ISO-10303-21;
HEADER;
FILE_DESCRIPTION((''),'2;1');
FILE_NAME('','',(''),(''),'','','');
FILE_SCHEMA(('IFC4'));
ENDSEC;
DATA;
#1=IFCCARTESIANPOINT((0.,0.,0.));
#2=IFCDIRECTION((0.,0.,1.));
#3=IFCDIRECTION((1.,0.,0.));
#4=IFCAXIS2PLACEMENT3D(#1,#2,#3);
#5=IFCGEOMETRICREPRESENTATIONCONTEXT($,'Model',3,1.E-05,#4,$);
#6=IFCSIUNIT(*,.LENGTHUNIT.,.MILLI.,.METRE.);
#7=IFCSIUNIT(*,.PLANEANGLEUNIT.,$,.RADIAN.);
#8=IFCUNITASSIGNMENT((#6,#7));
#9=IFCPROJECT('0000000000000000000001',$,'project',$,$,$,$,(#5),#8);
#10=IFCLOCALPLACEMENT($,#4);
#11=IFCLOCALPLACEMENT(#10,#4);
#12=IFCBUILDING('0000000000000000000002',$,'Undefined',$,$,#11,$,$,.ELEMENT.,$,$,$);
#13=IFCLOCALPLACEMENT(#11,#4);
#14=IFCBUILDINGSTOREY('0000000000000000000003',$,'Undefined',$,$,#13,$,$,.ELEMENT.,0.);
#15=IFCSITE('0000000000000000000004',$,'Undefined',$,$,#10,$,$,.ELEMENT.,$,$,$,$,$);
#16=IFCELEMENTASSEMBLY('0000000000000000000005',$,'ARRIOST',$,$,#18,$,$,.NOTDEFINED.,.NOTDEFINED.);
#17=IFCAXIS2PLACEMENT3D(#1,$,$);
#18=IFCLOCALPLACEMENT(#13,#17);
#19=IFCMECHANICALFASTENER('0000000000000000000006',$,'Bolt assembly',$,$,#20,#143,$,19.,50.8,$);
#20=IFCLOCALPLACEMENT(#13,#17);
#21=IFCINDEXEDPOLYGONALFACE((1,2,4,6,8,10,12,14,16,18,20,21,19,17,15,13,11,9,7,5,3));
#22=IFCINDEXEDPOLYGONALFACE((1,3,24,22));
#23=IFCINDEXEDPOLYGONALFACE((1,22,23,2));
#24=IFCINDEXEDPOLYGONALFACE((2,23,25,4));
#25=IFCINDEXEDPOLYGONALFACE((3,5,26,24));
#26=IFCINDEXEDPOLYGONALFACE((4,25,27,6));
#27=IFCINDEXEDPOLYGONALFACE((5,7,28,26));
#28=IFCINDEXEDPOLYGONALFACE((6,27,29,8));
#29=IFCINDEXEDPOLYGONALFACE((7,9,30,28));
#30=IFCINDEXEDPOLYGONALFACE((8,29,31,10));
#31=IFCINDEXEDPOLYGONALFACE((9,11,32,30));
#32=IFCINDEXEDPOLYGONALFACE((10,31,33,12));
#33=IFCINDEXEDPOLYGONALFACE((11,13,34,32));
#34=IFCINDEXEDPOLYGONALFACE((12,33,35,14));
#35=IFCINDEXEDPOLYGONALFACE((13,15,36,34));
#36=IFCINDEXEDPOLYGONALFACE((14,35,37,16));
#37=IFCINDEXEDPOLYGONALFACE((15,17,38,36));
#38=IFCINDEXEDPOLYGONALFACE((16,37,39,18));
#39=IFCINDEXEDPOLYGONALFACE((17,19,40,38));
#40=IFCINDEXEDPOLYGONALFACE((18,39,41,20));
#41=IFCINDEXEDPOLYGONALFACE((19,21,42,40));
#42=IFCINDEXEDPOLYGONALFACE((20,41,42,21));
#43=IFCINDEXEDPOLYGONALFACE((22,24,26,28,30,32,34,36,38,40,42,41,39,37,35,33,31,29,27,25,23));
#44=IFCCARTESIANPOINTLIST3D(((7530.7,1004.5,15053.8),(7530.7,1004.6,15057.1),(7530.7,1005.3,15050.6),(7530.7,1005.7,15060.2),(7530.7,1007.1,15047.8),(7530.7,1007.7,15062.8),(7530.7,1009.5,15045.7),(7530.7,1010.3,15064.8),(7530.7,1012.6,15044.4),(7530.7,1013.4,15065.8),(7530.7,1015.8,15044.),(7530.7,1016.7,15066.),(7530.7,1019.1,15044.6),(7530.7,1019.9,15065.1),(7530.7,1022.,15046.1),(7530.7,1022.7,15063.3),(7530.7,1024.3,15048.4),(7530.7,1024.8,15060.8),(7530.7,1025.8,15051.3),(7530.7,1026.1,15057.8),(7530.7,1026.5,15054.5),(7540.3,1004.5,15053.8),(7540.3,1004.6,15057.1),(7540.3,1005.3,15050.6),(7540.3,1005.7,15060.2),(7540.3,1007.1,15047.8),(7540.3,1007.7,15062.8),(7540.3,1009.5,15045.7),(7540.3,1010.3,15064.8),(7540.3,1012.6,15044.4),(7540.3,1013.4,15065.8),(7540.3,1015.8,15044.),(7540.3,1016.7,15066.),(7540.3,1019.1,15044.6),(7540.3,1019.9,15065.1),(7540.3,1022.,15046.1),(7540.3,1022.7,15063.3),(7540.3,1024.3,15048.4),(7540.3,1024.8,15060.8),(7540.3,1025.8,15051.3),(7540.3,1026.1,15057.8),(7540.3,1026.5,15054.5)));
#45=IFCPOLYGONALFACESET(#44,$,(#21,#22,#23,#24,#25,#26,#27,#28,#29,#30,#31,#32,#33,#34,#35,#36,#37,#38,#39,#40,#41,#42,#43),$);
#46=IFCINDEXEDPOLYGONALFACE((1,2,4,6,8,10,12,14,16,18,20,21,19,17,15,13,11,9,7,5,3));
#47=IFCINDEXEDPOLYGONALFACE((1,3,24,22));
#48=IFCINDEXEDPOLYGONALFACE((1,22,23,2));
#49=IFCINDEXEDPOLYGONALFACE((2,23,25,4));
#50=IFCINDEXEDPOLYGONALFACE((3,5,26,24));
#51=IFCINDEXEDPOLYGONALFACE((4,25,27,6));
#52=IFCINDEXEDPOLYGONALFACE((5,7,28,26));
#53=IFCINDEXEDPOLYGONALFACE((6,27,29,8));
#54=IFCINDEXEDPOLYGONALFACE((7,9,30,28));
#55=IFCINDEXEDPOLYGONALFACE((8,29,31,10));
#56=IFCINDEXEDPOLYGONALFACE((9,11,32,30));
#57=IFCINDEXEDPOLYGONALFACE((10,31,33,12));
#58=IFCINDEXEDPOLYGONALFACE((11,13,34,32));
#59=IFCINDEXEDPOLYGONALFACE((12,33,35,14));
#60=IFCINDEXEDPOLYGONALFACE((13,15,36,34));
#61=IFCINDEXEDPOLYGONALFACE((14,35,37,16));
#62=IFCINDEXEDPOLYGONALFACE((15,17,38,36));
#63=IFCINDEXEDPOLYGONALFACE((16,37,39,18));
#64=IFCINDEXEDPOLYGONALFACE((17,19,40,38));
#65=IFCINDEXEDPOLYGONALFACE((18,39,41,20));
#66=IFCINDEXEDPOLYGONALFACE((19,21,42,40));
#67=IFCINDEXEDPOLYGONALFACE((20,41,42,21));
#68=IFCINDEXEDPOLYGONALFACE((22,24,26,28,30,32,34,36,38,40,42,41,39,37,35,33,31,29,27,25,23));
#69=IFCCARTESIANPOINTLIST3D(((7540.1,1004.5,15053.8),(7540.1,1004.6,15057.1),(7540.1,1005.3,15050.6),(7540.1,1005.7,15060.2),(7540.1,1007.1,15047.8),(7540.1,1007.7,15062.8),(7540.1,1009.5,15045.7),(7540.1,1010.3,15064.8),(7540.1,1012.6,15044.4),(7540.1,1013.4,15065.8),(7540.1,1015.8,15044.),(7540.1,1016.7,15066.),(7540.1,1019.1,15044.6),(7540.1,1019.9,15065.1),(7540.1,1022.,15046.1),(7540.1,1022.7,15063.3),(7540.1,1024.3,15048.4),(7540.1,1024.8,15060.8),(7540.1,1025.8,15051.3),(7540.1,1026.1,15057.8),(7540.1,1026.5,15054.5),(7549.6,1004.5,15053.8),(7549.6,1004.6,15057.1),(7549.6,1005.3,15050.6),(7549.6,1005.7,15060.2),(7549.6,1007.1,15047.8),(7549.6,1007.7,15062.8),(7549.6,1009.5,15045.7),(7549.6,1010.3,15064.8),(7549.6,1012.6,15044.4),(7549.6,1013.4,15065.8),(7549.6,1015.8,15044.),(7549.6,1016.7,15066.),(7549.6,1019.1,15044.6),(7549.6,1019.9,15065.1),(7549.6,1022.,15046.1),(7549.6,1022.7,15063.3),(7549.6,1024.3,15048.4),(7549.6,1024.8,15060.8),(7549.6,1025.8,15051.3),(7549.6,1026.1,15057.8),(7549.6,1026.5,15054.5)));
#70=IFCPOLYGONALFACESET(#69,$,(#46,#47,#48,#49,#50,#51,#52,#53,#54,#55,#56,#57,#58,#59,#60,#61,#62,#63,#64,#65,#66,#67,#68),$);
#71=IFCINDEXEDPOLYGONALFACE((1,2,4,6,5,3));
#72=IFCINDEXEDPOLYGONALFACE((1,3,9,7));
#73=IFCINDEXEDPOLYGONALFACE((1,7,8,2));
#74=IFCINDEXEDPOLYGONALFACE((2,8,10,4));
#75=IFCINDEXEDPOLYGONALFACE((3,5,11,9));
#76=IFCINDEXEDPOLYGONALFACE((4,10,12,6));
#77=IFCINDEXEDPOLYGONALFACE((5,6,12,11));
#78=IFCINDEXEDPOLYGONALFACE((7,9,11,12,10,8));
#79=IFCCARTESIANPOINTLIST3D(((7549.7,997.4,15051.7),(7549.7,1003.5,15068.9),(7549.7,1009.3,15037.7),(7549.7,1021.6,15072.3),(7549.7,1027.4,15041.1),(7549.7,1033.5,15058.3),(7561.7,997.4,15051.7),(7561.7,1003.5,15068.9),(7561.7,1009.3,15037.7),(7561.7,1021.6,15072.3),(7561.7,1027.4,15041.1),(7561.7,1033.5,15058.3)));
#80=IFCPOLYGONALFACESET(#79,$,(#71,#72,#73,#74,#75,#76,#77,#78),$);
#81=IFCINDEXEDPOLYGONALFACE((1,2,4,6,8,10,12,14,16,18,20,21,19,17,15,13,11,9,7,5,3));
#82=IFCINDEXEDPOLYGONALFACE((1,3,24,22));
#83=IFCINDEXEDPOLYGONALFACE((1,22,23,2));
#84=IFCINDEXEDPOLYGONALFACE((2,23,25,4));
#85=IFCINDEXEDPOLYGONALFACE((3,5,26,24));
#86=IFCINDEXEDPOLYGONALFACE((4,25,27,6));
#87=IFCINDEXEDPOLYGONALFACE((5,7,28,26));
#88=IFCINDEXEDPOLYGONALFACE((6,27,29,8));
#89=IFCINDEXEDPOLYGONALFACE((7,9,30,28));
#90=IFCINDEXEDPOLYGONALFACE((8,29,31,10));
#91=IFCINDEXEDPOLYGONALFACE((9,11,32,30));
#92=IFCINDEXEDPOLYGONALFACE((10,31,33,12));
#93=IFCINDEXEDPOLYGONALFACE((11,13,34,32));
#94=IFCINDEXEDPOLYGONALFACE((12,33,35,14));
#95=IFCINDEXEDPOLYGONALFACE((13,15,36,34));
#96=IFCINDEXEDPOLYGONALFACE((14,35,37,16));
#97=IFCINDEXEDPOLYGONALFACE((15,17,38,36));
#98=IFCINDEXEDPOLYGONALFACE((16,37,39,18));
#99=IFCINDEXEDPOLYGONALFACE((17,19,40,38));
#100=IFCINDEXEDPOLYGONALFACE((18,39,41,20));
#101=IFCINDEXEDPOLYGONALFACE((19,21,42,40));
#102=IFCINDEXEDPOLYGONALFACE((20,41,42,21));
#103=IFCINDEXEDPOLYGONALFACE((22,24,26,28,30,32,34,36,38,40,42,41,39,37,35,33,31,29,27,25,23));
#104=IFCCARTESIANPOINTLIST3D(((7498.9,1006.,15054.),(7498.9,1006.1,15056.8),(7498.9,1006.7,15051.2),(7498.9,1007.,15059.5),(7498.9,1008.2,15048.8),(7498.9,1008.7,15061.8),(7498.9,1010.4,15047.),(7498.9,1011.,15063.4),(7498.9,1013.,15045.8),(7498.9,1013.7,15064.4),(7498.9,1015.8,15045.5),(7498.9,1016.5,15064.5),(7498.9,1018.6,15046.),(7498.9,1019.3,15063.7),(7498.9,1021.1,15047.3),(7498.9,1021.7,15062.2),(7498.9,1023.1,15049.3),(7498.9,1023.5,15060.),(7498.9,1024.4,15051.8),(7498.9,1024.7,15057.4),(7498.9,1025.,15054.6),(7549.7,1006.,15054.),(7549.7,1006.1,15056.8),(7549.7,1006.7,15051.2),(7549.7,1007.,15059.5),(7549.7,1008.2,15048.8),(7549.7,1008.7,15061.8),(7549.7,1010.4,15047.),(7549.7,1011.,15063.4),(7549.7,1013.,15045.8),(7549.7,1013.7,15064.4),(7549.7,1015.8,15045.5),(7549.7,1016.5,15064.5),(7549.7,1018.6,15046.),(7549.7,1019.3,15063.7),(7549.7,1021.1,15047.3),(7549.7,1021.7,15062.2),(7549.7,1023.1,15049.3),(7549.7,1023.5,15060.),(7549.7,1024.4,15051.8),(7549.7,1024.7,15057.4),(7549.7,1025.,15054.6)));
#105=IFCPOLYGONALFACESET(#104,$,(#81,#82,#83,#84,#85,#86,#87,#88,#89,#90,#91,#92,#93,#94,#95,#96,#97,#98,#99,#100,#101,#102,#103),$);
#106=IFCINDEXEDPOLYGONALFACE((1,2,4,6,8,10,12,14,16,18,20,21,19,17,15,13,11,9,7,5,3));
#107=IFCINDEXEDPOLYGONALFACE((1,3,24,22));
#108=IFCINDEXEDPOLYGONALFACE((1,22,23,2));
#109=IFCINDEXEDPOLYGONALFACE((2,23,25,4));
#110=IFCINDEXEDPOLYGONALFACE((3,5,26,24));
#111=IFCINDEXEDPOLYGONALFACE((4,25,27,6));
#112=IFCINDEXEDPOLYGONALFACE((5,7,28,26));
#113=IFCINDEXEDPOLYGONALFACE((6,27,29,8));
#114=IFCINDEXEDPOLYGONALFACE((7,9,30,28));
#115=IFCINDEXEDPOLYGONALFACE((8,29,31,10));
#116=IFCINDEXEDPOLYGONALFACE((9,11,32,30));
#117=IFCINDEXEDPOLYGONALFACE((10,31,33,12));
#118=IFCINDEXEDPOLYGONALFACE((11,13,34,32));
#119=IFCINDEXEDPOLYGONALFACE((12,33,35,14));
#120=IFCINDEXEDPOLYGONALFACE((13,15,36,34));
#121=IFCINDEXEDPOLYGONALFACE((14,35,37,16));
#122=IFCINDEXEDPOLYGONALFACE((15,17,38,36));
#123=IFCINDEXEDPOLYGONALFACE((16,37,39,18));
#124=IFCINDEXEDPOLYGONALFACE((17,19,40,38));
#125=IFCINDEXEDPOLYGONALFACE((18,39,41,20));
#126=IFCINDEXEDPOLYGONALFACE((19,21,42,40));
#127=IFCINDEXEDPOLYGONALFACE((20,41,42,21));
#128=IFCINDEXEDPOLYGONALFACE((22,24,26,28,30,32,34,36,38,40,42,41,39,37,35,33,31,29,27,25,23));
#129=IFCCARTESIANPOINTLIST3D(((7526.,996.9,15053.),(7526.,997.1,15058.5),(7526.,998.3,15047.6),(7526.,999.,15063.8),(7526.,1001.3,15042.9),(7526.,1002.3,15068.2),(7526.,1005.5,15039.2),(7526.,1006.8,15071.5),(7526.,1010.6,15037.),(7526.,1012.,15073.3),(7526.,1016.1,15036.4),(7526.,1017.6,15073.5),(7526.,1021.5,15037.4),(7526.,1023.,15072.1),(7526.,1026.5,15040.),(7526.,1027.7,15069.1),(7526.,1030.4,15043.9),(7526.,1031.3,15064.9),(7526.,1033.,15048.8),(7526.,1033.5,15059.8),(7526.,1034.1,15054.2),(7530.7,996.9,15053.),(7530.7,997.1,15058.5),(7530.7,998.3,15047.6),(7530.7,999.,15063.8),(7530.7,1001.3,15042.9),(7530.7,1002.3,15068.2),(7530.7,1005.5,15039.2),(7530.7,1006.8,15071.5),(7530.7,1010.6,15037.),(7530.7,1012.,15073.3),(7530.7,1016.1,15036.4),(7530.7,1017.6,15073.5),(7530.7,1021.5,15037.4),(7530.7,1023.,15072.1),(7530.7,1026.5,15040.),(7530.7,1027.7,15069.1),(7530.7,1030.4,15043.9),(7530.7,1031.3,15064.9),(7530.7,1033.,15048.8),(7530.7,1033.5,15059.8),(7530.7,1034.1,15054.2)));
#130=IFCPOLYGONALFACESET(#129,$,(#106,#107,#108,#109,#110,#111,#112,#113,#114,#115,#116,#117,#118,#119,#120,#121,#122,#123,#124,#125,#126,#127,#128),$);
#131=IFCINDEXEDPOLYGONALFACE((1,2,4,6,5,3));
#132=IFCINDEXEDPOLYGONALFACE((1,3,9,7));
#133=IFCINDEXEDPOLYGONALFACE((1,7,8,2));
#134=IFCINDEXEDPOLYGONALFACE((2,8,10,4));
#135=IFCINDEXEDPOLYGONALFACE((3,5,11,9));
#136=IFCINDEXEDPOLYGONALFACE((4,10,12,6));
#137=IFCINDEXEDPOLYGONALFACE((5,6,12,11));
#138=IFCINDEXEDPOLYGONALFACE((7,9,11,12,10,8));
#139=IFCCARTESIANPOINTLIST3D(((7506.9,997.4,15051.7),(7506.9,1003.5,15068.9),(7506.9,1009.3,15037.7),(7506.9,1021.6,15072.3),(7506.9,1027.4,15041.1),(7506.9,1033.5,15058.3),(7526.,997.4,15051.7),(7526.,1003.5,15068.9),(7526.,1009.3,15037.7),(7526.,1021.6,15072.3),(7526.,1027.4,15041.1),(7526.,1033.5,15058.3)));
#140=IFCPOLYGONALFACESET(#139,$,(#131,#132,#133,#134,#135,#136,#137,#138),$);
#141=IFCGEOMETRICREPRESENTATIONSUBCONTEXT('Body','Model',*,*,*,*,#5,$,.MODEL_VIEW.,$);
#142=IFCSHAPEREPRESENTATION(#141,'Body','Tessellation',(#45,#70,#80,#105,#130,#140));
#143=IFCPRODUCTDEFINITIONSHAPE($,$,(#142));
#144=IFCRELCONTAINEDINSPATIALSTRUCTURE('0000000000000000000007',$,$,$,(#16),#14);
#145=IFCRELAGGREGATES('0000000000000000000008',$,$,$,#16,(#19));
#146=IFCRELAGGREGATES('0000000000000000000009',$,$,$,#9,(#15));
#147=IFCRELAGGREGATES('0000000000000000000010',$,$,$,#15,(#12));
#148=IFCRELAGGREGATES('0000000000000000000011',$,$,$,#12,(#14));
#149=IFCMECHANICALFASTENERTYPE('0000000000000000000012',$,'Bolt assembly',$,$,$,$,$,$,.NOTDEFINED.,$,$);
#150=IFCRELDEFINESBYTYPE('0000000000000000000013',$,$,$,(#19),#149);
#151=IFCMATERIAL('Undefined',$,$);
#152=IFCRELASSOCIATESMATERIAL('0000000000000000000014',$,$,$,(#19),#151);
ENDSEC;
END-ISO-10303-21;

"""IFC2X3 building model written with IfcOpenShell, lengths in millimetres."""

from ifc_helpers import new_model, si_unit, frame, origin_with_axes, origin_2d_with_axis, place, context, subcontext, project, spatial, polyline, circle, outline, extrude, source, transform, mapped, material, type_object, element, aggregate, save


model = new_model("IFC2X3")

# Units and contexts
model_context = context("Model", 3, precision=1e-05, world=origin_with_axes())
body_context = subcontext(model_context, "Body", "Model", "MODEL_VIEW")
ifc_project = project(units=[si_unit("LENGTHUNIT", "METRE", prefix="MILLI"), si_unit("PLANEANGLEUNIT", "RADIAN")], contexts=[model_context])

# Site, building, storey
site_placement = place(None, origin_with_axes())
site = spatial("IfcSite", under=ifc_project, at=site_placement, Name="Undefined", CompositionType="ELEMENT")
building_placement = place(site_placement, origin_with_axes())
building = spatial("IfcBuilding", under=site, at=building_placement, Name="Undefined", CompositionType="ELEMENT")
storey_placement = place(building_placement, origin_with_axes())
storey = spatial("IfcBuildingStorey", under=building, at=storey_placement, Name="Undefined", CompositionType="ELEMENT", Elevation=0.0)

# Element assembly
assembly_1_placement = place(storey_placement, origin_with_axes())
assembly_1 = element("IfcElementAssembly", 1, at=assembly_1_placement, inside=storey, Name="ARRIOST", AssemblyPlace="NOTDEFINED", PredefinedType="NOTDEFINED")

# Shared definitions
ifc_material_1 = material(Name="Undefined")
mechanical_fastener_type = type_object("IfcMechanicalFastenerType", Name="Bolt assembly")

# Mechanical fastener
shared_shape_1 = source(origin_with_axes(), body_context, "Body", "SweptSolid", [
    extrude(circle(Radius=11.0, at=origin_2d_with_axis()), frame((0.0, 4.6, 0.0), z_axis=(0.0, 1.0, 0.0), x_axis=(1.0, 0.0, 0.0)), (0.0, 0.0, 1.0), 9.6),
    extrude(circle(Radius=11.0, at=origin_2d_with_axis()), frame((0.0, -4.6, 0.0), z_axis=(0.0, 1.0, 0.0), x_axis=(1.0, 0.0, 0.0)), (0.0, 0.0, 1.0), 9.5),
    extrude(outline(polyline([(15.9, -9.2), (15.9, 9.2), (0.0, 18.3), (-15.9, 9.2), (-15.9, -9.2), (0.0, -18.3), (15.9, -9.2)])), frame((0.0, -16.7, 0.0), z_axis=(0.0, 1.0, 0.0), x_axis=(1.0, 0.0, 0.0)), (0.0, 0.0, 1.0), 11.9),
    extrude(circle(Radius=9.5, at=origin_2d_with_axis()), frame((0.0, -4.7, 0.0), z_axis=(0.0, 1.0, 0.0), x_axis=(1.0, 0.0, 0.0)), (0.0, 0.0, 1.0), 50.8),
    extrude(circle(Radius=18.7, at=origin_2d_with_axis()), frame((0.0, 14.2, 0.0), z_axis=(0.0, 1.0, 0.0), x_axis=(1.0, 0.0, 0.0)), (0.0, 0.0, 1.0), 4.8),
    extrude(outline(polyline([(15.9, -9.2), (15.9, 9.2), (0.0, 18.3), (-15.9, 9.2), (-15.9, -9.2), (0.0, -18.3), (15.9, -9.2)])), frame((0.0, 19.0, 0.0), z_axis=(0.0, 1.0, 0.0), x_axis=(1.0, 0.0, 0.0)), (0.0, 0.0, 1.0), 19.1),
])
mechanical_fastener_1_placement = place(assembly_1_placement, frame((7545.0, 1015.4, 15055.0), z_axis=(0.0, 0.33354, 0.942736), x_axis=(0.0, 0.942736, -0.33354)))
mechanical_fastener_1 = element("IfcMechanicalFastener", 2, at=mechanical_fastener_1_placement, type_object=mechanical_fastener_type, material=ifc_material_1, Name="Bolt assembly", NominalDiameter=19.0, NominalLength=50.8, context=body_context, shape_type="MappedRepresentation", body=[
    mapped(shared_shape_1, transform((0.0, 0.0, 0.0))),
])
aggregate(assembly_1, [mechanical_fastener_1])

save(model, "model.ifc")
